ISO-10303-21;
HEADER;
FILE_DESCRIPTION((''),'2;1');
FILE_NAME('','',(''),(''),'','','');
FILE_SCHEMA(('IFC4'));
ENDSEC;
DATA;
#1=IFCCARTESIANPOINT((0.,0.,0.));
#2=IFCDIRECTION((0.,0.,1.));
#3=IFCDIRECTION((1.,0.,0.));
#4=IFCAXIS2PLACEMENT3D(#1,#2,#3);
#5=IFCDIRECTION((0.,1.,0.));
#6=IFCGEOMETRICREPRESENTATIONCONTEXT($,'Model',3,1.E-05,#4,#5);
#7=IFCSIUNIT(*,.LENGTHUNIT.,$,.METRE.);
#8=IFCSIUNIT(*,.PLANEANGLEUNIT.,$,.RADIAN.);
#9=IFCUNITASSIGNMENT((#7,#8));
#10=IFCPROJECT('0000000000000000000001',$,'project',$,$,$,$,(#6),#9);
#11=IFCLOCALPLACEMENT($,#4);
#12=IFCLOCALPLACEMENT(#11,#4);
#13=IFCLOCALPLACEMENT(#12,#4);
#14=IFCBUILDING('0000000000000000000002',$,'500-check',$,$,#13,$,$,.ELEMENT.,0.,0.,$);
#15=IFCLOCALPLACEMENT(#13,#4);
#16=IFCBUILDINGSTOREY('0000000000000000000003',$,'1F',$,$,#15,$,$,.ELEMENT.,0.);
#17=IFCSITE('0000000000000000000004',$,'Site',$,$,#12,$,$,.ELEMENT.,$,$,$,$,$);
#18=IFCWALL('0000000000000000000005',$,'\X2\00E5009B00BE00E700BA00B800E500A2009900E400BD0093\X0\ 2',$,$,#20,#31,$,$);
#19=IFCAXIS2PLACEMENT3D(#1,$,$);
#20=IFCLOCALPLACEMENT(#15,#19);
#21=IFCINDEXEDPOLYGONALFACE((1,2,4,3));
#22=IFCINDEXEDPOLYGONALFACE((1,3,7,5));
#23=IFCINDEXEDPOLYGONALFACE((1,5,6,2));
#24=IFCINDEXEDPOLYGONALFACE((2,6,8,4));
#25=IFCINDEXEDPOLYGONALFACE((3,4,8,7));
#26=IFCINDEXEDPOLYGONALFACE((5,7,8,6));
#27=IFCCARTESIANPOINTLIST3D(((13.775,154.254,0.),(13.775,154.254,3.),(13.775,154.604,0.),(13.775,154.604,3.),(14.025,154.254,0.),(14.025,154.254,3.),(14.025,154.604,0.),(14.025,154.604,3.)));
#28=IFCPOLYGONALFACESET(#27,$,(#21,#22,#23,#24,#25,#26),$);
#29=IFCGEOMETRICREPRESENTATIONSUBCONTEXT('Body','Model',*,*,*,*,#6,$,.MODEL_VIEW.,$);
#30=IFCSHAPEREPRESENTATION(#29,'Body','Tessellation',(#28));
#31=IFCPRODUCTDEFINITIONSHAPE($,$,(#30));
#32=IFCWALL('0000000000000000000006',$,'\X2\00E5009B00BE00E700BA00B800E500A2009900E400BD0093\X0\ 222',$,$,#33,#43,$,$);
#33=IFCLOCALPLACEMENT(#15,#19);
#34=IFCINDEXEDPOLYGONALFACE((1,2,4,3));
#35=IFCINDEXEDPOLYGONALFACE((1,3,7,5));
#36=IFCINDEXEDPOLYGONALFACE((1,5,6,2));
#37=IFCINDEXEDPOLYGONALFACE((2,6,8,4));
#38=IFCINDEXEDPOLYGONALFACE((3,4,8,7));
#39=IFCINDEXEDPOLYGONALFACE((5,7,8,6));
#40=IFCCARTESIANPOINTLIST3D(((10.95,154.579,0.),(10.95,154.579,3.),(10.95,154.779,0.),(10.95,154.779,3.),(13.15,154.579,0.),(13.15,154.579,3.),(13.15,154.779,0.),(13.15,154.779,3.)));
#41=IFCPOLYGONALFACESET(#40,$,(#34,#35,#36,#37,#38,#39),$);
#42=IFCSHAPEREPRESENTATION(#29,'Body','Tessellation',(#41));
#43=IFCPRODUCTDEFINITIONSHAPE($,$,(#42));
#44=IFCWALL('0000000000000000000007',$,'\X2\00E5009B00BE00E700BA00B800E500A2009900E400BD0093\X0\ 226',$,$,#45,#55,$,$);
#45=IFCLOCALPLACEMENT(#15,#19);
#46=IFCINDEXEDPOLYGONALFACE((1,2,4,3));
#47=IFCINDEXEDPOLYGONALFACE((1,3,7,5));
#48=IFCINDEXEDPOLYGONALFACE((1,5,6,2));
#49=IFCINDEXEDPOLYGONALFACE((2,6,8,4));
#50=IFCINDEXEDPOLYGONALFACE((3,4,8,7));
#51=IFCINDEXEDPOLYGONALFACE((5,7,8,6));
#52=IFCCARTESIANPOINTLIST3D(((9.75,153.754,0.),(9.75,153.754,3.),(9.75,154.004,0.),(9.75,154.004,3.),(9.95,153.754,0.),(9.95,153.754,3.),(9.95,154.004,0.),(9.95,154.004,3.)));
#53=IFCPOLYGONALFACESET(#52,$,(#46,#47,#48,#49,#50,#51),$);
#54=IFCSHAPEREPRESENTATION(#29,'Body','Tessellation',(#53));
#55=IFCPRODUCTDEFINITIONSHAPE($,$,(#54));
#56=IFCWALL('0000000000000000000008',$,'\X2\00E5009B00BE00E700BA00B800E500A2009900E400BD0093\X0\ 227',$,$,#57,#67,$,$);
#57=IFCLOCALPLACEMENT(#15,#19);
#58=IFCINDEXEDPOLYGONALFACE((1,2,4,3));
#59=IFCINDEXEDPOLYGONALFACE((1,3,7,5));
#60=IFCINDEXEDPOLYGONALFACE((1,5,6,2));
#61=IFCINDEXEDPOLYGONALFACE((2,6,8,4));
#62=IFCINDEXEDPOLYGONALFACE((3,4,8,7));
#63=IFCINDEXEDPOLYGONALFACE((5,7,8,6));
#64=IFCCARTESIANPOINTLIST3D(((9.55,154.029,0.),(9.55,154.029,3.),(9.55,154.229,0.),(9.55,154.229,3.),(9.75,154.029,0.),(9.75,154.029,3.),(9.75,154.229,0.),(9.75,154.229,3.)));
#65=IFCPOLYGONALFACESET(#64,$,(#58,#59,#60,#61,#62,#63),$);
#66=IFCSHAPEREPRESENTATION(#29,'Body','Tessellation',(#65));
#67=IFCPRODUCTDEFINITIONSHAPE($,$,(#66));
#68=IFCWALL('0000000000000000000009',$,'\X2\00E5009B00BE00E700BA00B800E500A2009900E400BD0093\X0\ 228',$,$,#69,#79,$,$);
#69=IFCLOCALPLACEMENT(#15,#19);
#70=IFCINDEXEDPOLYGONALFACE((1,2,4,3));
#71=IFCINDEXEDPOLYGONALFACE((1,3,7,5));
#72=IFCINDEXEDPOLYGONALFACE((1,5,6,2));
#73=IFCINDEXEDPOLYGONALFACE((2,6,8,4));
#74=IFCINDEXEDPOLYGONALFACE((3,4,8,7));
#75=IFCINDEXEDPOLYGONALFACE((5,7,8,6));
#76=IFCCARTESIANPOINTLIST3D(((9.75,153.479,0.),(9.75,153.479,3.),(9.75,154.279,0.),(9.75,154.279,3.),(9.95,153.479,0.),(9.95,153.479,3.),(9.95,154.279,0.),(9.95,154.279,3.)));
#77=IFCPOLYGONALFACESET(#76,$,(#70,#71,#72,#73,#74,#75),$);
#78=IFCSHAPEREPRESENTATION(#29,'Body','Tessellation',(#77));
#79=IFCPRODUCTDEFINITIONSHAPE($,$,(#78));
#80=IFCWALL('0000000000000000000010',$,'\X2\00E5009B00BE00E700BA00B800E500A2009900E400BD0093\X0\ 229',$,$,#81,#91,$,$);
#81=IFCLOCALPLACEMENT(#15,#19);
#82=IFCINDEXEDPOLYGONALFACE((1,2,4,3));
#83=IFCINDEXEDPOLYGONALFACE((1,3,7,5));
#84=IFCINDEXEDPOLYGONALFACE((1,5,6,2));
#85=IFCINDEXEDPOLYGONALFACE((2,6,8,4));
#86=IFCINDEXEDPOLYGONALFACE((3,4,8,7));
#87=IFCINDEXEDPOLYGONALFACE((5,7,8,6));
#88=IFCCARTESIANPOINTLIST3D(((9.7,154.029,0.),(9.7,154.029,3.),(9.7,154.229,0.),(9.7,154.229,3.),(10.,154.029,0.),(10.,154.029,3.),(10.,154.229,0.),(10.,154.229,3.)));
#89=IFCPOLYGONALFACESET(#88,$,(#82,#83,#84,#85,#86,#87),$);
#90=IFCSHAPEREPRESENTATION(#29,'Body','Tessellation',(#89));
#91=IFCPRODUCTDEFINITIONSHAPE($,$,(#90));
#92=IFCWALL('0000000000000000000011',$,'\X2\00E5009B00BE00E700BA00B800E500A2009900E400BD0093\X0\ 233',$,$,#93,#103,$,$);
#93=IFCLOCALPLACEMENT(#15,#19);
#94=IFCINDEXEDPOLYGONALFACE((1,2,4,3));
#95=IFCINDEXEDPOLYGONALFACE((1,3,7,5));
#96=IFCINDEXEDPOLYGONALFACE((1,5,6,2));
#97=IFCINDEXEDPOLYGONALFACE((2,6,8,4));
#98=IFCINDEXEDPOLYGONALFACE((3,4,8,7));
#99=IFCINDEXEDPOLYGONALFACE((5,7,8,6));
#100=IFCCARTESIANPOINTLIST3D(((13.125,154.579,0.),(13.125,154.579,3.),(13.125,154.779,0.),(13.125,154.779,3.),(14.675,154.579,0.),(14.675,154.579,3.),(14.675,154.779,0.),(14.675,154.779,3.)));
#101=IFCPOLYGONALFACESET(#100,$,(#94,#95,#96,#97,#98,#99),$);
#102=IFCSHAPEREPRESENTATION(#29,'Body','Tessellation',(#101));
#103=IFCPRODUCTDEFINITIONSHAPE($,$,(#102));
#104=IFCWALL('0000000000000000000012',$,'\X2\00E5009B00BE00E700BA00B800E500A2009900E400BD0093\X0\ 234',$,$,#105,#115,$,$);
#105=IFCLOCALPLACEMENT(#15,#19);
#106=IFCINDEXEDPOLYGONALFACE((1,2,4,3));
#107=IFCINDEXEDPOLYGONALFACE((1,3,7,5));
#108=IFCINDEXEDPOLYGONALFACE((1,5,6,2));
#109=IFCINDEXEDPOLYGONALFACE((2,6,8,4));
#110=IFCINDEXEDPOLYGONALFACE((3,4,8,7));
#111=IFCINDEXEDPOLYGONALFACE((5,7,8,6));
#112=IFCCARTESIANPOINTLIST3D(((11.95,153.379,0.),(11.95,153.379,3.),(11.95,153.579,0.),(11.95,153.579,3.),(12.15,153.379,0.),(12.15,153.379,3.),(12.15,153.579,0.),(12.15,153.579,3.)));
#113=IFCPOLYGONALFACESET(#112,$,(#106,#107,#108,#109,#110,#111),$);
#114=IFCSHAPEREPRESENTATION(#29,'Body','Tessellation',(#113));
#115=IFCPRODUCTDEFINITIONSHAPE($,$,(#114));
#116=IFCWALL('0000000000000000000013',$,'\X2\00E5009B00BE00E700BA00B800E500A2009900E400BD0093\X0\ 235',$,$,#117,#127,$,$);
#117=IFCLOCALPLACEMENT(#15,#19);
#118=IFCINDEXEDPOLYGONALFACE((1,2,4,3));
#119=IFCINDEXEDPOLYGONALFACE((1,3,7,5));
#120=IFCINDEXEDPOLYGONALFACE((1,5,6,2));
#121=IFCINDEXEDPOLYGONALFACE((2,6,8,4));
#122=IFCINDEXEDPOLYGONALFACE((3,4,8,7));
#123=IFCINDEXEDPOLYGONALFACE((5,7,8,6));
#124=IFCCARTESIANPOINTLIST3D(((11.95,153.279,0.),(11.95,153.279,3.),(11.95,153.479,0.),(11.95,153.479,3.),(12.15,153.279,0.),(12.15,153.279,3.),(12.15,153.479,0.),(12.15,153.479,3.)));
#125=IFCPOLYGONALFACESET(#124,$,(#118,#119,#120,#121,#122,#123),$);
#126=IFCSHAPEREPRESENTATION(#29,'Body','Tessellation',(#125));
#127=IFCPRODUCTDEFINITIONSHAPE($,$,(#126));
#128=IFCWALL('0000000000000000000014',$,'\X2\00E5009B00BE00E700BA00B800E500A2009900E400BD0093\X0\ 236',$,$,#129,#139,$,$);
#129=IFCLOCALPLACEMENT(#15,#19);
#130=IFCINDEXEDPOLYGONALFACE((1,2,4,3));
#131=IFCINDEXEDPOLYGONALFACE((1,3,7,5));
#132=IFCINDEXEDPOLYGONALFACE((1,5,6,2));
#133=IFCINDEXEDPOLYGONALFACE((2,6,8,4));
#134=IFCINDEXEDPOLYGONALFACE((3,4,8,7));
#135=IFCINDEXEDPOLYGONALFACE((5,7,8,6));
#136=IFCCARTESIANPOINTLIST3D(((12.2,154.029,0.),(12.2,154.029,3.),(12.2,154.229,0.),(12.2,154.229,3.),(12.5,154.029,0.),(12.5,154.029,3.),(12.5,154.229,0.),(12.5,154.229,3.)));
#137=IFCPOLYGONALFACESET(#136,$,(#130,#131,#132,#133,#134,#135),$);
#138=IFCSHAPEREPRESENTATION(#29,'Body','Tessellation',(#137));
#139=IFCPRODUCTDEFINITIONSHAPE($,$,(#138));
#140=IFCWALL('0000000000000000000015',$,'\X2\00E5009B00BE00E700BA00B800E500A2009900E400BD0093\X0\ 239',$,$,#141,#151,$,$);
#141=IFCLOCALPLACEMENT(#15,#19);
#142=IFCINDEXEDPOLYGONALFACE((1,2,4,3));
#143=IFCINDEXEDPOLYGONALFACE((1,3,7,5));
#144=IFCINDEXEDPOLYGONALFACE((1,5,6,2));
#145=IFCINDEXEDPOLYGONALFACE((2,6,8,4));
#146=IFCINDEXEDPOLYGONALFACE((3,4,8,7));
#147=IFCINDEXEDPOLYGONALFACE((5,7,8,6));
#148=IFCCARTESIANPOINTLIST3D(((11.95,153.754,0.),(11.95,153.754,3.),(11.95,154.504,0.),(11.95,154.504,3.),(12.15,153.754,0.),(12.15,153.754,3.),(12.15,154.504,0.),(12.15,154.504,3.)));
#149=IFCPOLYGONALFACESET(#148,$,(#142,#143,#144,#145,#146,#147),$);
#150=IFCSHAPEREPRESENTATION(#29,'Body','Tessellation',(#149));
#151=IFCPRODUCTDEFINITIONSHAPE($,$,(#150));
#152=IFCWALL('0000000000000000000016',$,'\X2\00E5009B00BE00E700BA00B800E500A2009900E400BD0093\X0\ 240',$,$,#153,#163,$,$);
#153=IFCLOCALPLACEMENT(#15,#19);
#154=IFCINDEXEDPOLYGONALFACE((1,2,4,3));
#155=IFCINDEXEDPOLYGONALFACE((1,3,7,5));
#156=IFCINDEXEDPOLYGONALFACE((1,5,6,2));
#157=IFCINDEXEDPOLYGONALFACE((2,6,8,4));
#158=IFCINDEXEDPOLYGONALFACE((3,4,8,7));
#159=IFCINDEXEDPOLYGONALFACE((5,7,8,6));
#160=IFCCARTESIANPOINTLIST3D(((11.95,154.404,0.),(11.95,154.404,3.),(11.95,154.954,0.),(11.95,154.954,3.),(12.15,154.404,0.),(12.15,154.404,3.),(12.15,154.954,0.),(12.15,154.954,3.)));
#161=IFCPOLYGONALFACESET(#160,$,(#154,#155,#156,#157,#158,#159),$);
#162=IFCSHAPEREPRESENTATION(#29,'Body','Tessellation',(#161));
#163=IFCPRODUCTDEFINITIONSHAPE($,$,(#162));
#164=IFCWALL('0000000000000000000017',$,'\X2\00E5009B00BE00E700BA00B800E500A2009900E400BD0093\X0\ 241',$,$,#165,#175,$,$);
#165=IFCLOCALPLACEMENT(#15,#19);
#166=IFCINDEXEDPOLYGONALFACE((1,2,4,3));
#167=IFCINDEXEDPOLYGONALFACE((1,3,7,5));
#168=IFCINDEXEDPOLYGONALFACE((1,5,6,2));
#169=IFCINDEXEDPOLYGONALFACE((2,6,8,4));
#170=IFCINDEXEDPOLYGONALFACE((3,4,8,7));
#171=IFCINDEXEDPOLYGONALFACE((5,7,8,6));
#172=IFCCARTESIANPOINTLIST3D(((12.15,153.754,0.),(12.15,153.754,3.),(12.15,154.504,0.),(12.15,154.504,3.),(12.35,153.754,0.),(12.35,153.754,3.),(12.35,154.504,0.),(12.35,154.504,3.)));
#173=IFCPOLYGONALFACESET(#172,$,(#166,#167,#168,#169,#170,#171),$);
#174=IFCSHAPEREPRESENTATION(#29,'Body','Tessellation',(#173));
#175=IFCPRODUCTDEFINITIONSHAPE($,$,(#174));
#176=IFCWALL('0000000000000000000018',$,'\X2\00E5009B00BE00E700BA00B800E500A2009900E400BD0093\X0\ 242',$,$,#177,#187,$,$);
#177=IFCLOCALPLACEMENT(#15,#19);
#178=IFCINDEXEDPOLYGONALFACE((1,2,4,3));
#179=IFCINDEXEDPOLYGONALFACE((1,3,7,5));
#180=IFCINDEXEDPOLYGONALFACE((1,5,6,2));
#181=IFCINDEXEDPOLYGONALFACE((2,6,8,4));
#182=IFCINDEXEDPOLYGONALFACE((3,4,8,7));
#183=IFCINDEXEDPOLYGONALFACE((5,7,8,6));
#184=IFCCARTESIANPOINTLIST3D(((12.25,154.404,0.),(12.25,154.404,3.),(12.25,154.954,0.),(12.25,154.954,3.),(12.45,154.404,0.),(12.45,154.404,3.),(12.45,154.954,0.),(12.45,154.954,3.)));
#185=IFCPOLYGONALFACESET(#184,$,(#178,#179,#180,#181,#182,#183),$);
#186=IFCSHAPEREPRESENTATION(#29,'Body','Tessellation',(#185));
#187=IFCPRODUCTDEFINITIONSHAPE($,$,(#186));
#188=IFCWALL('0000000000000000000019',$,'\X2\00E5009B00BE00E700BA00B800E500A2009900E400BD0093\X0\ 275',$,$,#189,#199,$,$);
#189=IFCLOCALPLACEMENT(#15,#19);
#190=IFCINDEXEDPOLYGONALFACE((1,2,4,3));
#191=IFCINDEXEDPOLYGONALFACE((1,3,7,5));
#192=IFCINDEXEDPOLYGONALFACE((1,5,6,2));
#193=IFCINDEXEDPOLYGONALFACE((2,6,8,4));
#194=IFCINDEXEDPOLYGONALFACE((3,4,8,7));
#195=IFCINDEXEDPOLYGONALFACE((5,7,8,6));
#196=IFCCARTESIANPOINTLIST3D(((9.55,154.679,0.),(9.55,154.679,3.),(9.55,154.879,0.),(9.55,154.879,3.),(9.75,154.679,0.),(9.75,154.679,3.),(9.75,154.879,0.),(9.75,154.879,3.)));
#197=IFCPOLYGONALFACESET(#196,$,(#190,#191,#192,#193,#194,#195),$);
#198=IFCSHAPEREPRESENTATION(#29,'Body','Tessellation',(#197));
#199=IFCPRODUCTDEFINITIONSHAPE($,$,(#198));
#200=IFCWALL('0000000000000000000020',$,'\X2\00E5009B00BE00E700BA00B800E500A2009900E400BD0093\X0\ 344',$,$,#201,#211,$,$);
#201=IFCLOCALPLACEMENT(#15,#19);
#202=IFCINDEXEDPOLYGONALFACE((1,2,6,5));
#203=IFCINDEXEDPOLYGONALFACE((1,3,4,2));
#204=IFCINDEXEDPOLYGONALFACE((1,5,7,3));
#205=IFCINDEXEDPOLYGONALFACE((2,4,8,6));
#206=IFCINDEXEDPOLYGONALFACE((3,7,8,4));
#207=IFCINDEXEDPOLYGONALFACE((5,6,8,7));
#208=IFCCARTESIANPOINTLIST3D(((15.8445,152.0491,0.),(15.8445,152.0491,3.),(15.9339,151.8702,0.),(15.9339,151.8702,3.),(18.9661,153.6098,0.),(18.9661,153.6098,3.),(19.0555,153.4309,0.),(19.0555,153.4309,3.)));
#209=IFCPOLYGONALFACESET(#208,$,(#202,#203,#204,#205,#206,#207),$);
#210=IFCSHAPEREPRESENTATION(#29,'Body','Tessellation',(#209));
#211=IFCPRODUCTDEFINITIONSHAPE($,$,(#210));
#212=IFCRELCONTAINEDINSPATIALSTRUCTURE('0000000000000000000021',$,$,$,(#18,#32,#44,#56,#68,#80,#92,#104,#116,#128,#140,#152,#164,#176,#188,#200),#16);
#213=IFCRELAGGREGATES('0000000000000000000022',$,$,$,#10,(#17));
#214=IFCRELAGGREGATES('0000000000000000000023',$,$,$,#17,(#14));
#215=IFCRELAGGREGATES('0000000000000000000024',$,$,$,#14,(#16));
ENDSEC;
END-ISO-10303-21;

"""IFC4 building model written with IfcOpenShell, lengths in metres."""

from ifc_helpers import new_model, si_unit, direction, frame, frame_2d, origin_with_axes, place, context, subcontext, project, spatial, rectangle, extrude, element, save


model = new_model("IFC4")

# Units and contexts
model_context = context("Model", 3, precision=1e-05, world=origin_with_axes(), true_north=direction((0.0, 1.0, 0.0)))
body_context = subcontext(model_context, "Body", "Model", "MODEL_VIEW")
ifc_project = project(units=[si_unit("LENGTHUNIT", "METRE"), si_unit("PLANEANGLEUNIT", "RADIAN")], contexts=[model_context])

# Site, building, storey
placement = place(None, origin_with_axes())
site_placement = place(placement, origin_with_axes())
site = spatial("IfcSite", under=ifc_project, at=site_placement, Name="Site", CompositionType="ELEMENT")
building_placement = place(site_placement, origin_with_axes())
building = spatial("IfcBuilding", under=site, at=building_placement, Name="500-check", CompositionType="ELEMENT", ElevationOfRefHeight=0.0, ElevationOfTerrain=0.0)
storey_placement = place(building_placement, origin_with_axes())
storey = spatial("IfcBuildingStorey", under=building, at=storey_placement, Name="1F", CompositionType="ELEMENT", Elevation=0.0)

# Walls
for number, where, z_axis, x_axis, name in (
    (1, (13.9, 154.429, 0.0), (0.0, 0.0, 1.0), (1.0, 0.0, 0.0), "å\u009b¾çº¸å¢\u0099ä½\u0093 2"),
):
    element("IfcWall", number, at=place(storey_placement, frame(where, z_axis=z_axis, x_axis=x_axis)), inside=storey, Name=name, context=body_context, shape_type="SweptSolid", body=[
        extrude(rectangle(XDim=0.25, YDim=0.35, at=frame_2d((0.0, 0.0), x_axis=(1.0, 0.0, 0.0))), frame((0.0, 0.0, 0.0), z_axis=(0.0, 0.0, 1.0)), (0.0, 0.0, 1.0), 3.0),
    ])
wall_1_placement = place(storey_placement, frame((12.05, 154.679, 0.0), z_axis=(0.0, 0.0, 1.0), x_axis=(-1.0, 0.0, 0.0)))
element("IfcWall", 2, at=wall_1_placement, inside=storey, Name="å\u009b¾çº¸å¢\u0099ä½\u0093 222", context=body_context, shape_type="SweptSolid", body=[
    extrude(rectangle(XDim=2.2, YDim=0.2, at=frame_2d((0.0, 0.0), x_axis=(1.0, 0.0, 0.0))), frame((0.0, 0.0, 0.0), z_axis=(0.0, 0.0, 1.0)), (0.0, 0.0, 1.0), 3.0),
])
wall_2_placement = place(storey_placement, frame((9.85, 153.879, 0.0), z_axis=(0.0, 0.0, 1.0), x_axis=(0.0, 1.0, 0.0)))
element("IfcWall", 3, at=wall_2_placement, inside=storey, Name="å\u009b¾çº¸å¢\u0099ä½\u0093 226", context=body_context, shape_type="SweptSolid", body=[
    extrude(rectangle(XDim=0.25, YDim=0.2, at=frame_2d((0.0, 0.0), x_axis=(1.0, 0.0, 0.0))), frame((0.0, 0.0, 0.0), z_axis=(0.0, 0.0, 1.0)), (0.0, 0.0, 1.0), 3.0),
])
wall_3_placement = place(storey_placement, frame((9.65, 154.129, 0.0), z_axis=(0.0, 0.0, 1.0), x_axis=(1.0, 0.0, 0.0)))
element("IfcWall", 4, at=wall_3_placement, inside=storey, Name="å\u009b¾çº¸å¢\u0099ä½\u0093 227", context=body_context, shape_type="SweptSolid", body=[
    extrude(rectangle(XDim=0.2, YDim=0.2, at=frame_2d((0.0, 0.0), x_axis=(1.0, 0.0, 0.0))), frame((0.0, 0.0, 0.0), z_axis=(0.0, 0.0, 1.0)), (0.0, 0.0, 1.0), 3.0),
])
wall_4_placement = place(storey_placement, frame((9.85, 153.879, 0.0), z_axis=(0.0, 0.0, 1.0), x_axis=(0.0, 1.0, 0.0)))
element("IfcWall", 5, at=wall_4_placement, inside=storey, Name="å\u009b¾çº¸å¢\u0099ä½\u0093 228", context=body_context, shape_type="SweptSolid", body=[
    extrude(rectangle(XDim=0.8, YDim=0.2, at=frame_2d((0.0, 0.0), x_axis=(1.0, 0.0, 0.0))), frame((0.0, 0.0, 0.0), z_axis=(0.0, 0.0, 1.0)), (0.0, 0.0, 1.0), 3.0),
])
wall_5_placement = place(storey_placement, frame((9.85, 154.129, 0.0), z_axis=(0.0, 0.0, 1.0), x_axis=(-1.0, 0.0, 0.0)))
element("IfcWall", 6, at=wall_5_placement, inside=storey, Name="å\u009b¾çº¸å¢\u0099ä½\u0093 229", context=body_context, shape_type="SweptSolid", body=[
    extrude(rectangle(XDim=0.3, YDim=0.2, at=frame_2d((0.0, 0.0), x_axis=(1.0, 0.0, 0.0))), frame((0.0, 0.0, 0.0), z_axis=(0.0, 0.0, 1.0)), (0.0, 0.0, 1.0), 3.0),
])
wall_6_placement = place(storey_placement, frame((13.9, 154.679, 0.0), z_axis=(0.0, 0.0, 1.0), x_axis=(-1.0, 0.0, 0.0)))
element("IfcWall", 7, at=wall_6_placement, inside=storey, Name="å\u009b¾çº¸å¢\u0099ä½\u0093 233", context=body_context, shape_type="SweptSolid", body=[
    extrude(rectangle(XDim=1.55, YDim=0.2, at=frame_2d((0.0, 0.0), x_axis=(1.0, 0.0, 0.0))), frame((0.0, 0.0, 0.0), z_axis=(0.0, 0.0, 1.0)), (0.0, 0.0, 1.0), 3.0),
])
for number, where, z_axis, x_axis, name in (
    (8, (12.05, 153.479, 0.0), (0.0, 0.0, 1.0), (1.0, 0.0, 0.0), "å\u009b¾çº¸å¢\u0099ä½\u0093 234"),
    (9, (12.05, 153.379, 0.0), (0.0, 0.0, 1.0), (1.0, 0.0, 0.0), "å\u009b¾çº¸å¢\u0099ä½\u0093 235"),
):
    element("IfcWall", number, at=place(storey_placement, frame(where, z_axis=z_axis, x_axis=x_axis)), inside=storey, Name=name, context=body_context, shape_type="SweptSolid", body=[
        extrude(rectangle(XDim=0.2, YDim=0.2, at=frame_2d((0.0, 0.0), x_axis=(1.0, 0.0, 0.0))), frame((0.0, 0.0, 0.0), z_axis=(0.0, 0.0, 1.0)), (0.0, 0.0, 1.0), 3.0),
    ])
wall_7_placement = place(storey_placement, frame((12.35, 154.129, 0.0), z_axis=(0.0, 0.0, 1.0), x_axis=(-1.0, 0.0, 0.0)))
element("IfcWall", 10, at=wall_7_placement, inside=storey, Name="å\u009b¾çº¸å¢\u0099ä½\u0093 236", context=body_context, shape_type="SweptSolid", body=[
    extrude(rectangle(XDim=0.3, YDim=0.2, at=frame_2d((0.0, 0.0), x_axis=(1.0, 0.0, 0.0))), frame((0.0, 0.0, 0.0), z_axis=(0.0, 0.0, 1.0)), (0.0, 0.0, 1.0), 3.0),
])
wall_8_placement = place(storey_placement, frame((12.05, 154.129, 0.0), z_axis=(0.0, 0.0, 1.0), x_axis=(0.0, -1.0, 0.0)))
element("IfcWall", 11, at=wall_8_placement, inside=storey, Name="å\u009b¾çº¸å¢\u0099ä½\u0093 239", context=body_context, shape_type="SweptSolid", body=[
    extrude(rectangle(XDim=0.75, YDim=0.2, at=frame_2d((0.0, 0.0), x_axis=(1.0, 0.0, 0.0))), frame((0.0, 0.0, 0.0), z_axis=(0.0, 0.0, 1.0)), (0.0, 0.0, 1.0), 3.0),
])
wall_9_placement = place(storey_placement, frame((12.05, 154.679, 0.0), z_axis=(0.0, 0.0, 1.0), x_axis=(0.0, -1.0, 0.0)))
element("IfcWall", 12, at=wall_9_placement, inside=storey, Name="å\u009b¾çº¸å¢\u0099ä½\u0093 240", context=body_context, shape_type="SweptSolid", body=[
    extrude(rectangle(XDim=0.55, YDim=0.2, at=frame_2d((0.0, 0.0), x_axis=(1.0, 0.0, 0.0))), frame((0.0, 0.0, 0.0), z_axis=(0.0, 0.0, 1.0)), (0.0, 0.0, 1.0), 3.0),
])
wall_10_placement = place(storey_placement, frame((12.25, 154.129, 0.0), z_axis=(0.0, 0.0, 1.0), x_axis=(0.0, -1.0, 0.0)))
element("IfcWall", 13, at=wall_10_placement, inside=storey, Name="å\u009b¾çº¸å¢\u0099ä½\u0093 241", context=body_context, shape_type="SweptSolid", body=[
    extrude(rectangle(XDim=0.75, YDim=0.2, at=frame_2d((0.0, 0.0), x_axis=(1.0, 0.0, 0.0))), frame((0.0, 0.0, 0.0), z_axis=(0.0, 0.0, 1.0)), (0.0, 0.0, 1.0), 3.0),
])
wall_11_placement = place(storey_placement, frame((12.35, 154.679, 0.0), z_axis=(0.0, 0.0, 1.0), x_axis=(0.0, -1.0, 0.0)))
element("IfcWall", 14, at=wall_11_placement, inside=storey, Name="å\u009b¾çº¸å¢\u0099ä½\u0093 242", context=body_context, shape_type="SweptSolid", body=[
    extrude(rectangle(XDim=0.55, YDim=0.2, at=frame_2d((0.0, 0.0), x_axis=(1.0, 0.0, 0.0))), frame((0.0, 0.0, 0.0), z_axis=(0.0, 0.0, 1.0)), (0.0, 0.0, 1.0), 3.0),
])
wall_12_placement = place(storey_placement, frame((9.65, 154.779, 0.0), z_axis=(0.0, 0.0, 1.0), x_axis=(1.0, 0.0, 0.0)))
element("IfcWall", 15, at=wall_12_placement, inside=storey, Name="å\u009b¾çº¸å¢\u0099ä½\u0093 275", context=body_context, shape_type="SweptSolid", body=[
    extrude(rectangle(XDim=0.2, YDim=0.2, at=frame_2d((0.0, 0.0), x_axis=(1.0, 0.0, 0.0))), frame((0.0, 0.0, 0.0), z_axis=(0.0, 0.0, 1.0)), (0.0, 0.0, 1.0), 3.0),
])
wall_13_placement = place(storey_placement, frame((17.45, 152.74, 0.0), z_axis=(0.0, 0.0, 1.0), x_axis=(-0.894428, -0.447213, 0.0)))
element("IfcWall", 16, at=wall_13_placement, inside=storey, Name="å\u009b¾çº¸å¢\u0099ä½\u0093 344", context=body_context, shape_type="SweptSolid", body=[
    extrude(rectangle(XDim=3.49, YDim=0.2, at=frame_2d((0.0, 0.0), x_axis=(1.0, 0.0, 0.0))), frame((0.0, 0.0, 0.0), z_axis=(0.0, 0.0, 1.0)), (0.0, 0.0, 1.0), 3.0),
])

save(model, "model.ifc")
